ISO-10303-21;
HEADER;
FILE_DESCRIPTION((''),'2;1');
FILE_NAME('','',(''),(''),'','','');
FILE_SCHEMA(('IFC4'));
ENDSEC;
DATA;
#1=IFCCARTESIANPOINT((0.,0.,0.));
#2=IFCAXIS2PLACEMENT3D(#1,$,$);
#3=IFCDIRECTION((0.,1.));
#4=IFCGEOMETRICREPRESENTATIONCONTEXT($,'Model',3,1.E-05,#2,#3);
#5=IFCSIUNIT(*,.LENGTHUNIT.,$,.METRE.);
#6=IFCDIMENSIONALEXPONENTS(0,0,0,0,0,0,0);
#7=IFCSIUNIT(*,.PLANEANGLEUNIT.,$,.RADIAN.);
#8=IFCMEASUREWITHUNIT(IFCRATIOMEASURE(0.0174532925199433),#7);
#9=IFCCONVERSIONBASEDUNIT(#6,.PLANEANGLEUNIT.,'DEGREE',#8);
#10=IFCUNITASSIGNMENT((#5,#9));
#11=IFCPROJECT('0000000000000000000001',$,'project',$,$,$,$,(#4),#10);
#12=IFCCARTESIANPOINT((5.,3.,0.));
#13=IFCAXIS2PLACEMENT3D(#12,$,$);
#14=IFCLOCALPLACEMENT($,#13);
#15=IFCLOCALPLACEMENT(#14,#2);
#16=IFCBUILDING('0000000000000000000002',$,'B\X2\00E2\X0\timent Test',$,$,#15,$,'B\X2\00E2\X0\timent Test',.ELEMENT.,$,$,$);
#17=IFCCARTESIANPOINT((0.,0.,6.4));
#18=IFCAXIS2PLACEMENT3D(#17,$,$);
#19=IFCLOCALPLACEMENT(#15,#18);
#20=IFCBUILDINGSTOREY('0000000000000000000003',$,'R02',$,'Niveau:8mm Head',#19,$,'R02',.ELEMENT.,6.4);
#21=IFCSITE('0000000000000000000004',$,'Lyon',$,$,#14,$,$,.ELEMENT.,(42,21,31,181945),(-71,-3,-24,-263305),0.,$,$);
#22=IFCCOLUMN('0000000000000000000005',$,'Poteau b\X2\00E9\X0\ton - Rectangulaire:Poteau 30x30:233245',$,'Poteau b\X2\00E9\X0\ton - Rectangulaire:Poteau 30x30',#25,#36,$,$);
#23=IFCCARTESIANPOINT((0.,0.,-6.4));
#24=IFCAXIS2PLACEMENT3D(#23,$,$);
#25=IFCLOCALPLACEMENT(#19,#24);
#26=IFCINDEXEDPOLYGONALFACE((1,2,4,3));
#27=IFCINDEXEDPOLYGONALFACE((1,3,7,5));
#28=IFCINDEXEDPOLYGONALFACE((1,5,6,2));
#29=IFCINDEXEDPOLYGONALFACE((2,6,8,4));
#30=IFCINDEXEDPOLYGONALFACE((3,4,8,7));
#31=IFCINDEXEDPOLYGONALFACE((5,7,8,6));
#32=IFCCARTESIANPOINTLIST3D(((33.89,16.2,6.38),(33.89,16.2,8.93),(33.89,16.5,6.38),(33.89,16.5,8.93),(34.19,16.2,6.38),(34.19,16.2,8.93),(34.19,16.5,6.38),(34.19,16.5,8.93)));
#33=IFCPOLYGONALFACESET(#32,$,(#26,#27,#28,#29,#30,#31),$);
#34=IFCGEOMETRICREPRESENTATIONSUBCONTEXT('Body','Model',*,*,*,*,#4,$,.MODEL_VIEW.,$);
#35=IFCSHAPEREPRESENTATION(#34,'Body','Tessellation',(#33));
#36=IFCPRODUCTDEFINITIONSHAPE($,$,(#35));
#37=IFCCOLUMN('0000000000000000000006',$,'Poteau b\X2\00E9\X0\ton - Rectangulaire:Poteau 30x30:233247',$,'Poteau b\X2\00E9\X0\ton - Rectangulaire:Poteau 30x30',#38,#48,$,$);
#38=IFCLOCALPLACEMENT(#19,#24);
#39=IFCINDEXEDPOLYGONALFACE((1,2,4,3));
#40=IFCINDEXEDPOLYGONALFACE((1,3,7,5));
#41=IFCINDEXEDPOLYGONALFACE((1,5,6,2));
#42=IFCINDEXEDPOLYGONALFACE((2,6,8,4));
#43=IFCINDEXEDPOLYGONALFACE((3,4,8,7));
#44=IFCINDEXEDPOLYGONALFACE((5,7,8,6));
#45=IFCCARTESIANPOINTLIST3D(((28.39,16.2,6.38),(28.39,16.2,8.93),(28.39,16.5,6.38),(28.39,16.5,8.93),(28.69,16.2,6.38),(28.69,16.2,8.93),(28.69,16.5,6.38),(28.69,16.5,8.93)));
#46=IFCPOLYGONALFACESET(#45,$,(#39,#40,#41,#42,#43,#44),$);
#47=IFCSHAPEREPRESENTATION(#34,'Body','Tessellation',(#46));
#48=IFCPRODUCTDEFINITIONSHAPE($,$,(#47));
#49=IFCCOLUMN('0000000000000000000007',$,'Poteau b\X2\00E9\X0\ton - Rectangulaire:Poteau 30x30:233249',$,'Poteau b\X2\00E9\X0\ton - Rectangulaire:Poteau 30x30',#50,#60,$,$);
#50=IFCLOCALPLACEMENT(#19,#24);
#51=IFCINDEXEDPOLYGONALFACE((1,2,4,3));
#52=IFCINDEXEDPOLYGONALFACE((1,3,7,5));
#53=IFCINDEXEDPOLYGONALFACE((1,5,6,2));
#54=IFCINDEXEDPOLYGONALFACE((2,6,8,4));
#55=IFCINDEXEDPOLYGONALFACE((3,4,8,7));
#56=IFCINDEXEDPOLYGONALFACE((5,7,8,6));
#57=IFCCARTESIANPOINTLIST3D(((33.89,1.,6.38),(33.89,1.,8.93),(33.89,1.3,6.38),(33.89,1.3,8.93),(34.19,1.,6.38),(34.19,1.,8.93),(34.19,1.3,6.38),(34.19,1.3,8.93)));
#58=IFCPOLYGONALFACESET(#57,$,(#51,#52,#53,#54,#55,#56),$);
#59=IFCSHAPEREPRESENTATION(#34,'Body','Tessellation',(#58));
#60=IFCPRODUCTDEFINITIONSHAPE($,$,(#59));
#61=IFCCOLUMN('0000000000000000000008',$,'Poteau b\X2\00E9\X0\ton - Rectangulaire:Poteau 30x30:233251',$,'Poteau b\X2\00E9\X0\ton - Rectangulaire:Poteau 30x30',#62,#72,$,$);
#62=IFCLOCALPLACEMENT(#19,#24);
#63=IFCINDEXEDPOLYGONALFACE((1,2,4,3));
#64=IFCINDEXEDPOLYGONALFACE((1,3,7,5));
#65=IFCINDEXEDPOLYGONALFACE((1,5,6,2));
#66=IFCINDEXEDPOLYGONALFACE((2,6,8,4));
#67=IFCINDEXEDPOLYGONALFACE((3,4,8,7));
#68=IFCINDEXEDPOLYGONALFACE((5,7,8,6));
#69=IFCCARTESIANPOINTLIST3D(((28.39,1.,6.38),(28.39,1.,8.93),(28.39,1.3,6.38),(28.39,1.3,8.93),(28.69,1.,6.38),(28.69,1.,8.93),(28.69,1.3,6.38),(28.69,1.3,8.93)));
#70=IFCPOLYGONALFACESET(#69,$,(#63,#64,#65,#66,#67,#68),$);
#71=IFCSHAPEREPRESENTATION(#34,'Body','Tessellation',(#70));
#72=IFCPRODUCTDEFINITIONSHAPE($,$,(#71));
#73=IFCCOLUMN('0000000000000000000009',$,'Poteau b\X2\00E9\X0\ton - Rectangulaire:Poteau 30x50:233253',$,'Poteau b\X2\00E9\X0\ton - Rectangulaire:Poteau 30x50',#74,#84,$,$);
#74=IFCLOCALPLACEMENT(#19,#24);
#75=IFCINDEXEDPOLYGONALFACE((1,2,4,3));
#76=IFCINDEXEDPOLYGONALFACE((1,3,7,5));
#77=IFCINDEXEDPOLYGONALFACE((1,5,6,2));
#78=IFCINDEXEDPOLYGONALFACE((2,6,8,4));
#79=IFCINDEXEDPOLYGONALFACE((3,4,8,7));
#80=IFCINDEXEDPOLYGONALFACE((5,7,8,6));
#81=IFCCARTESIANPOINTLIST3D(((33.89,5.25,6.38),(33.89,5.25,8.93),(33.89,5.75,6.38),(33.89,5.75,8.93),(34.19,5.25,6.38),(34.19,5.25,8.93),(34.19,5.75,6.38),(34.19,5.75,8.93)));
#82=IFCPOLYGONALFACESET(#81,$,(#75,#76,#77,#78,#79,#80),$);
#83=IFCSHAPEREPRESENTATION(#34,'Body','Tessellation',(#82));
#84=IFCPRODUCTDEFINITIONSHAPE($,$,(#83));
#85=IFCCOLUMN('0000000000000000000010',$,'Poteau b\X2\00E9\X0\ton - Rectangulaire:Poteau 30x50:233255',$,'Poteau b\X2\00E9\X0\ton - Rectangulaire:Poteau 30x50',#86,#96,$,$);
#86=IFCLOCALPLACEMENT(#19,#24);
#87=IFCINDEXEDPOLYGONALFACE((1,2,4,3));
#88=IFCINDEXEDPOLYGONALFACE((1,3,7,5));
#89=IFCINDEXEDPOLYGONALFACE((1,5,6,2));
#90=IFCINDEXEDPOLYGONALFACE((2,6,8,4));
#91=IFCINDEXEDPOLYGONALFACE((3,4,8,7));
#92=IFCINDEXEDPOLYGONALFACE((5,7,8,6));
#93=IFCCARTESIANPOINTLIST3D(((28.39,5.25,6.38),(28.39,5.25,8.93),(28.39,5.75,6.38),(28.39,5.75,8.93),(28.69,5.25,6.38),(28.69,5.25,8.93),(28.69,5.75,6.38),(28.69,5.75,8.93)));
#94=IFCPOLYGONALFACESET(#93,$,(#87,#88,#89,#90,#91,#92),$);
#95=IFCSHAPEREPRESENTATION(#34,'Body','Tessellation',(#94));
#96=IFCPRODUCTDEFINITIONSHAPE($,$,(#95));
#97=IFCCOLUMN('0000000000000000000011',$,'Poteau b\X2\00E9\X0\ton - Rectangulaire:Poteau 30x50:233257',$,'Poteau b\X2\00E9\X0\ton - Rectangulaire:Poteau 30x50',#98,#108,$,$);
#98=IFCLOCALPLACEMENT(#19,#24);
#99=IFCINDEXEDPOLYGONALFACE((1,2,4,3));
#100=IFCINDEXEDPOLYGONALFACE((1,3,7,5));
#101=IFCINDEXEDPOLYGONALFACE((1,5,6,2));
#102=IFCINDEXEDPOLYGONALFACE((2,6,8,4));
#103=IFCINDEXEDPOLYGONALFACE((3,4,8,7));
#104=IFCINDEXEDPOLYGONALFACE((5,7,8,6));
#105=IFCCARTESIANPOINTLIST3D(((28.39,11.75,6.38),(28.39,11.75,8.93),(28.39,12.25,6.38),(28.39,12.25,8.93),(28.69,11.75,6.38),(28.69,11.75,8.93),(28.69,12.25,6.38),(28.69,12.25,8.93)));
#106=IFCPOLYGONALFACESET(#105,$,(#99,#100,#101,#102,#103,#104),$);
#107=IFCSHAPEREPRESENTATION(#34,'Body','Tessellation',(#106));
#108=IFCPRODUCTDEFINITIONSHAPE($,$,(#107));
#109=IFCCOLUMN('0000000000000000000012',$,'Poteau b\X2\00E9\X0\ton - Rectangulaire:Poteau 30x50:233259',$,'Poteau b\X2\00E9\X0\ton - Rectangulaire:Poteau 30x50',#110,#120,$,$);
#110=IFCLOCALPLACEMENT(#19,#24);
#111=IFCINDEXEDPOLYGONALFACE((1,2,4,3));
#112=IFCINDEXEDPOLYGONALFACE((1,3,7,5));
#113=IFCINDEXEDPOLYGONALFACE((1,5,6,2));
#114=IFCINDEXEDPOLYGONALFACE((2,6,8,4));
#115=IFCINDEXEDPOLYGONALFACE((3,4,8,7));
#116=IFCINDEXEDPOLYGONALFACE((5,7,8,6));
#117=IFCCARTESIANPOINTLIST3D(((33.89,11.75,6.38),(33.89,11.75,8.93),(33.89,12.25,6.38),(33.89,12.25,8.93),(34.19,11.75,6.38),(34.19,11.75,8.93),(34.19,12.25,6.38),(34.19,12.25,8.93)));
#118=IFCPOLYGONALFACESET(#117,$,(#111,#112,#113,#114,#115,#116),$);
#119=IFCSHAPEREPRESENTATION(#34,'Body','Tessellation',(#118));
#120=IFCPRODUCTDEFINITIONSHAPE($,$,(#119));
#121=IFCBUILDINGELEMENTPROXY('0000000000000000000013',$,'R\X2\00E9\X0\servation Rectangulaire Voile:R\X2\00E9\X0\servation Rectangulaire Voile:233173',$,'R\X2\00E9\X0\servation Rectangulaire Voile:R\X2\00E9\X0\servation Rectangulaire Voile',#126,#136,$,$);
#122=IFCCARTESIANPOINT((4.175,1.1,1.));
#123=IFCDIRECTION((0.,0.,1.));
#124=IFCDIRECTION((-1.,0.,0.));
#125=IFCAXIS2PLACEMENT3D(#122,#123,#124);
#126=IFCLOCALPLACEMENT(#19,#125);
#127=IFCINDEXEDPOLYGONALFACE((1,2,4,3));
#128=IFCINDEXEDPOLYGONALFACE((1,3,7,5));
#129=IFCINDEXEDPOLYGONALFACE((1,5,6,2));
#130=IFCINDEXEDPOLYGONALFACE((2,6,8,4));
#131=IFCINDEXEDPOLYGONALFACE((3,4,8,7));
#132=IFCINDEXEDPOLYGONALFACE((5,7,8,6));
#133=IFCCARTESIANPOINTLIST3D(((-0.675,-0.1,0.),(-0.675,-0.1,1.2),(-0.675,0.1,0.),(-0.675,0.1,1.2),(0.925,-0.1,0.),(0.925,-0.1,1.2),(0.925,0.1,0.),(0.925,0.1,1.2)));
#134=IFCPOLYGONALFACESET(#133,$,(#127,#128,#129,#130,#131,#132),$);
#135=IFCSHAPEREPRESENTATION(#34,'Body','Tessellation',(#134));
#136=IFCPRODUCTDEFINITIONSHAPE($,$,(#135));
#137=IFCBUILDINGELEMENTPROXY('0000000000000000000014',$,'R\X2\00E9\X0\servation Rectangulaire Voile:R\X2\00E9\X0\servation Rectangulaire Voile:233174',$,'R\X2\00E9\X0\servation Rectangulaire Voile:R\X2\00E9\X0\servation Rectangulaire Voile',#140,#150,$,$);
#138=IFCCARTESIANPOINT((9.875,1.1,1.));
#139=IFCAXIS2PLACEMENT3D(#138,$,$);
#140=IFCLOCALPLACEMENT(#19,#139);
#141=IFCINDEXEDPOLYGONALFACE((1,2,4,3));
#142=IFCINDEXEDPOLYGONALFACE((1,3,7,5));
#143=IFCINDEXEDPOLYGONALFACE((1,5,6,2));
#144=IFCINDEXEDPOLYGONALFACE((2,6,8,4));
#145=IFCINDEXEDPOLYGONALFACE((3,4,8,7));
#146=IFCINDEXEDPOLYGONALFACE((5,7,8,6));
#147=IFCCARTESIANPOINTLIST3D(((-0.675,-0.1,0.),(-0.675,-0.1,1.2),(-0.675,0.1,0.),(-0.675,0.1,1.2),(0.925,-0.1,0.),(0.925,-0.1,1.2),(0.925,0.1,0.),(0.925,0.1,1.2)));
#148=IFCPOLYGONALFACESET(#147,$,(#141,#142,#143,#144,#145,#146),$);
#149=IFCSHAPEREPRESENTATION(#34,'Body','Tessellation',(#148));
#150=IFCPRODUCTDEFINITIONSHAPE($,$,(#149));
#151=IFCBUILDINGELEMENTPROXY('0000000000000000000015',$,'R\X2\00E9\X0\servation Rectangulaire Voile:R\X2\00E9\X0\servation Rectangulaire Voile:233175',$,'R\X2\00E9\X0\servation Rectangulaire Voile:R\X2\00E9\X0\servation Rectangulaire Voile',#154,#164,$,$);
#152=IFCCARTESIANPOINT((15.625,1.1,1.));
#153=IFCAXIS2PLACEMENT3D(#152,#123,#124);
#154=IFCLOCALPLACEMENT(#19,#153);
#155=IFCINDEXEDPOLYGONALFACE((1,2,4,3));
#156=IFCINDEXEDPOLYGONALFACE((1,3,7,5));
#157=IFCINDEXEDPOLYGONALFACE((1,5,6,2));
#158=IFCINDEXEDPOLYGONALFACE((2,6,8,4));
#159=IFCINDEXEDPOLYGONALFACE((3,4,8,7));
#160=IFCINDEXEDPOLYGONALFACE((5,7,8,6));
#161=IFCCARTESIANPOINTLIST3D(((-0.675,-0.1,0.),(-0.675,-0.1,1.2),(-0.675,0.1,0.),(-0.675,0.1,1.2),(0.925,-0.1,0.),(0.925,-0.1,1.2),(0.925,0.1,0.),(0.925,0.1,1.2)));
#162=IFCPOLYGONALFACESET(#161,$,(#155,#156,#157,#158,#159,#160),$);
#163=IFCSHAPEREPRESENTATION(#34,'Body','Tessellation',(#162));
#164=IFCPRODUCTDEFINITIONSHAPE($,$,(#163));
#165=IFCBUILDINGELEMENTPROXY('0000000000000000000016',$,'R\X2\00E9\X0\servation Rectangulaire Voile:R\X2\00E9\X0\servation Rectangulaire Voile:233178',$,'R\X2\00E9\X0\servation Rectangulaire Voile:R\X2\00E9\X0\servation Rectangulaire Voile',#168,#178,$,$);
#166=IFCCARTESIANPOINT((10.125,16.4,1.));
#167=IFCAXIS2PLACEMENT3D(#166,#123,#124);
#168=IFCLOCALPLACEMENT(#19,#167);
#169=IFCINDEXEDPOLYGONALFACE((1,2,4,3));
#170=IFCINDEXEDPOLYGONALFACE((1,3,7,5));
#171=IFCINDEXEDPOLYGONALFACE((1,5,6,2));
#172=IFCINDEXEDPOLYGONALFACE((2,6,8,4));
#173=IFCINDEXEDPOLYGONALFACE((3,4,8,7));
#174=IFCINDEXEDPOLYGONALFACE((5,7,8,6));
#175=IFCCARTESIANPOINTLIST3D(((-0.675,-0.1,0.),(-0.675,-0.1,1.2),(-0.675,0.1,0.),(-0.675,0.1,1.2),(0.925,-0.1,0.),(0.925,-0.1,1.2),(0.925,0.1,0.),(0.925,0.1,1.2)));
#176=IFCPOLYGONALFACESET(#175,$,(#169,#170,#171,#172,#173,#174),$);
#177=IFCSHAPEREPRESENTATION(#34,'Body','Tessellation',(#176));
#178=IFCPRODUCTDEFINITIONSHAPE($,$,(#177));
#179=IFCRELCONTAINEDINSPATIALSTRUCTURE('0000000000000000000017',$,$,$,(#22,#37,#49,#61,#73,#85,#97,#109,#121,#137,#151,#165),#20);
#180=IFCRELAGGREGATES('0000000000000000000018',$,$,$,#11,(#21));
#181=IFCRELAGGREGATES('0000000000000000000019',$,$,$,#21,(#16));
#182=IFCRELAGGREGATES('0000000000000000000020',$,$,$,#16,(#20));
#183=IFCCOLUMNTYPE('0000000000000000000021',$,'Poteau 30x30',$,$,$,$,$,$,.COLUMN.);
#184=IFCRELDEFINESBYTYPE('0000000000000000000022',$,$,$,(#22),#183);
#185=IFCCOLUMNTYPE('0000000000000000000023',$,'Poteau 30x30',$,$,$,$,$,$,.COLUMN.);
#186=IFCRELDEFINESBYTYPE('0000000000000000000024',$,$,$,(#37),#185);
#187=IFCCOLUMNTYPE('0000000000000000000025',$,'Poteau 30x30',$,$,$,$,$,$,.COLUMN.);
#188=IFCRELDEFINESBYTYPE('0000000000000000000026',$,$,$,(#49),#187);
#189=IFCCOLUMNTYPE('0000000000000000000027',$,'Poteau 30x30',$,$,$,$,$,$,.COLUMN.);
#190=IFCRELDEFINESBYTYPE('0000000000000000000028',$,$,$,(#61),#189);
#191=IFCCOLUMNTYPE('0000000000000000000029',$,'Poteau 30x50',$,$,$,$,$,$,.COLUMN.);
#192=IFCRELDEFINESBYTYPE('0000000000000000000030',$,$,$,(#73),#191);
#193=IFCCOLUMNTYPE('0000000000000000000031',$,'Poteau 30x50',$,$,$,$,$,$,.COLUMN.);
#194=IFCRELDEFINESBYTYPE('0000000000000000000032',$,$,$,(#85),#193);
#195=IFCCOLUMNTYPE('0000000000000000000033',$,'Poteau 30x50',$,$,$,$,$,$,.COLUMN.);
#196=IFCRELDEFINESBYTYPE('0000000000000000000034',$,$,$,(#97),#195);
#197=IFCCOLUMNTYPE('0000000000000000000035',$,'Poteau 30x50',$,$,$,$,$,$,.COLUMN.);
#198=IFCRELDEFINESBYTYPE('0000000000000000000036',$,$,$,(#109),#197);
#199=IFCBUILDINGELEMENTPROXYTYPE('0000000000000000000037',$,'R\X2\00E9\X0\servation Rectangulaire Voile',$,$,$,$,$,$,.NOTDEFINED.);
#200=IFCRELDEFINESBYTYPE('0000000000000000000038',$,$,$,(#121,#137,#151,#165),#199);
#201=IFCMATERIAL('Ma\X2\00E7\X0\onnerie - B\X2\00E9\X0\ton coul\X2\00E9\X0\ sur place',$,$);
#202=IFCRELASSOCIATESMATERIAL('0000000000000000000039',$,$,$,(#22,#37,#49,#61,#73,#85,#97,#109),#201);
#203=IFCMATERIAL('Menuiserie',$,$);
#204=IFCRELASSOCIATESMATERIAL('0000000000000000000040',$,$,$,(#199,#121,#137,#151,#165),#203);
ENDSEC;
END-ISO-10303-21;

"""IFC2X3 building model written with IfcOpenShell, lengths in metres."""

from ifc_helpers import new_model, entity, si_unit, converted_unit, direction, frame, frame_2d, origin, origin_2d_with_axis, place, context, subcontext, project, spatial, rectangle, extrude, source, transform, mapped, material, type_object, type_shapes, element, save


model = new_model("IFC2X3")

# Units and contexts
model_context = context("Model", 3, precision=1e-05, world=origin(), true_north=direction((0.0, 1.0)))
body_context = subcontext(model_context, "Body", "Model", "MODEL_VIEW")
ifc_project = project(units=[si_unit("LENGTHUNIT", "METRE"), converted_unit("PLANEANGLEUNIT", "DEGREE", entity("IfcRatioMeasure", 0.0174532925199433), si_unit("PLANEANGLEUNIT", "RADIAN"), dimensions=[0, 0, 0, 0, 0, 0, 0])], contexts=[model_context])

# Site, building, storey
site_placement = place(None, frame((5.0, 3.0, 0.0)))
site = spatial("IfcSite", under=ifc_project, at=site_placement, Name="Lyon", CompositionType="ELEMENT", RefLatitude=(42, 21, 31, 181945), RefLongitude=(-71, -3, -24, -263305), RefElevation=0.0)
building_placement = place(site_placement, origin())
building = spatial("IfcBuilding", under=site, at=building_placement, Name="Bâtiment Test", LongName="Bâtiment Test", CompositionType="ELEMENT")
storey_placement = place(building_placement, frame((0.0, 0.0, 6.4)))
storey = spatial("IfcBuildingStorey", under=building, at=storey_placement, Name="R02", ObjectType="Niveau:8mm Head", LongName="R02", CompositionType="ELEMENT", Elevation=6.4)

# Columns
ifc_material_1 = material(Name="Maçonnerie - Béton coulé sur place")
column_type_1 = type_object("IfcColumnType", Name="Poteau 30x30", PredefinedType="COLUMN")
shared_shape_1 = source(origin(), body_context, "Body", "SweptSolid", [
    extrude(rectangle(XDim=0.3, YDim=0.3, at=origin_2d_with_axis()), frame((34.04, 16.35, 6.38), z_axis=(0.0, 0.0, 1.0), x_axis=(0.0, -1.0, 0.0)), (0.0, 0.0, 1.0), 2.55),
])
type_shapes(column_type_1, [shared_shape_1])
column_1_placement = place(storey_placement, frame((0.0, 0.0, -6.4)))
element("IfcColumn", 1, at=column_1_placement, inside=storey, type_object=column_type_1, material=ifc_material_1, Name="Poteau béton - Rectangulaire:Poteau 30x30:233245", ObjectType="Poteau béton - Rectangulaire:Poteau 30x30", context=body_context, shape_type="MappedRepresentation", body=[
    mapped(shared_shape_1, transform((0.0, 0.0, 0.0), scale=1.0)),
])
column_type_2 = type_object("IfcColumnType", Name="Poteau 30x30", PredefinedType="COLUMN")
shared_shape_2 = source(origin(), body_context, "Body", "SweptSolid", [
    extrude(rectangle(XDim=0.3, YDim=0.3, at=origin_2d_with_axis()), frame((28.54, 16.35, 6.38), z_axis=(0.0, 0.0, 1.0), x_axis=(0.0, -1.0, 0.0)), (0.0, 0.0, 1.0), 2.55),
])
type_shapes(column_type_2, [shared_shape_2])
column_2_placement = place(storey_placement, frame((0.0, 0.0, -6.4)))
element("IfcColumn", 2, at=column_2_placement, inside=storey, type_object=column_type_2, material=ifc_material_1, Name="Poteau béton - Rectangulaire:Poteau 30x30:233247", ObjectType="Poteau béton - Rectangulaire:Poteau 30x30", context=body_context, shape_type="MappedRepresentation", body=[
    mapped(shared_shape_2, transform((0.0, 0.0, 0.0), scale=1.0)),
])
column_type_3 = type_object("IfcColumnType", Name="Poteau 30x30", PredefinedType="COLUMN")
shared_shape_3 = source(origin(), body_context, "Body", "SweptSolid", [
    extrude(rectangle(XDim=0.3, YDim=0.3, at=frame_2d((0.0, 0.0), x_axis=(1.0, 0.0))), frame((34.04, 1.15, 6.38), z_axis=(0.0, 0.0, 1.0), x_axis=(0.0, -1.0, 0.0)), (0.0, 0.0, 1.0), 2.55),
])
type_shapes(column_type_3, [shared_shape_3])
column_3_placement = place(storey_placement, frame((0.0, 0.0, -6.4)))
element("IfcColumn", 3, at=column_3_placement, inside=storey, type_object=column_type_3, material=ifc_material_1, Name="Poteau béton - Rectangulaire:Poteau 30x30:233249", ObjectType="Poteau béton - Rectangulaire:Poteau 30x30", context=body_context, shape_type="MappedRepresentation", body=[
    mapped(shared_shape_3, transform((0.0, 0.0, 0.0), scale=1.0)),
])
column_type_4 = type_object("IfcColumnType", Name="Poteau 30x30", PredefinedType="COLUMN")
shared_shape_4 = source(origin(), body_context, "Body", "SweptSolid", [
    extrude(rectangle(XDim=0.3, YDim=0.3, at=frame_2d((0.0, 0.0), x_axis=(1.0, 0.0))), frame((28.54, 1.15, 6.38), z_axis=(0.0, 0.0, 1.0), x_axis=(0.0, -1.0, 0.0)), (0.0, 0.0, 1.0), 2.55),
])
type_shapes(column_type_4, [shared_shape_4])
column_4_placement = place(storey_placement, frame((0.0, 0.0, -6.4)))
element("IfcColumn", 4, at=column_4_placement, inside=storey, type_object=column_type_4, material=ifc_material_1, Name="Poteau béton - Rectangulaire:Poteau 30x30:233251", ObjectType="Poteau béton - Rectangulaire:Poteau 30x30", context=body_context, shape_type="MappedRepresentation", body=[
    mapped(shared_shape_4, transform((0.0, 0.0, 0.0), scale=1.0)),
])
column_type_5 = type_object("IfcColumnType", Name="Poteau 30x50", PredefinedType="COLUMN")
shared_shape_5 = source(origin(), body_context, "Body", "SweptSolid", [
    extrude(rectangle(XDim=0.5, YDim=0.3, at=origin_2d_with_axis()), frame((34.04, 5.5, 6.38), z_axis=(0.0, 0.0, 1.0), x_axis=(0.0, -1.0, 0.0)), (0.0, 0.0, 1.0), 2.55),
])
type_shapes(column_type_5, [shared_shape_5])
column_5_placement = place(storey_placement, frame((0.0, 0.0, -6.4)))
element("IfcColumn", 5, at=column_5_placement, inside=storey, type_object=column_type_5, material=ifc_material_1, Name="Poteau béton - Rectangulaire:Poteau 30x50:233253", ObjectType="Poteau béton - Rectangulaire:Poteau 30x50", context=body_context, shape_type="MappedRepresentation", body=[
    mapped(shared_shape_5, transform((0.0, 0.0, 0.0), scale=1.0)),
])
column_type_6 = type_object("IfcColumnType", Name="Poteau 30x50", PredefinedType="COLUMN")
shared_shape_6 = source(origin(), body_context, "Body", "SweptSolid", [
    extrude(rectangle(XDim=0.5, YDim=0.3, at=origin_2d_with_axis()), frame((28.54, 5.5, 6.38), z_axis=(0.0, 0.0, 1.0), x_axis=(0.0, -1.0, 0.0)), (0.0, 0.0, 1.0), 2.55),
])
type_shapes(column_type_6, [shared_shape_6])
column_6_placement = place(storey_placement, frame((0.0, 0.0, -6.4)))
element("IfcColumn", 6, at=column_6_placement, inside=storey, type_object=column_type_6, material=ifc_material_1, Name="Poteau béton - Rectangulaire:Poteau 30x50:233255", ObjectType="Poteau béton - Rectangulaire:Poteau 30x50", context=body_context, shape_type="MappedRepresentation", body=[
    mapped(shared_shape_6, transform((0.0, 0.0, 0.0), scale=1.0)),
])
column_type_7 = type_object("IfcColumnType", Name="Poteau 30x50", PredefinedType="COLUMN")
shared_shape_7 = source(origin(), body_context, "Body", "SweptSolid", [
    extrude(rectangle(XDim=0.5, YDim=0.3, at=origin_2d_with_axis()), frame((28.54, 12.0, 6.38), z_axis=(0.0, 0.0, 1.0), x_axis=(0.0, -1.0, 0.0)), (0.0, 0.0, 1.0), 2.55),
])
type_shapes(column_type_7, [shared_shape_7])
column_7_placement = place(storey_placement, frame((0.0, 0.0, -6.4)))
element("IfcColumn", 7, at=column_7_placement, inside=storey, type_object=column_type_7, material=ifc_material_1, Name="Poteau béton - Rectangulaire:Poteau 30x50:233257", ObjectType="Poteau béton - Rectangulaire:Poteau 30x50", context=body_context, shape_type="MappedRepresentation", body=[
    mapped(shared_shape_7, transform((0.0, 0.0, 0.0), scale=1.0)),
])
column_type_8 = type_object("IfcColumnType", Name="Poteau 30x50", PredefinedType="COLUMN")
shared_shape_8 = source(origin(), body_context, "Body", "SweptSolid", [
    extrude(rectangle(XDim=0.5, YDim=0.3, at=origin_2d_with_axis()), frame((34.04, 12.0, 6.38), z_axis=(0.0, 0.0, 1.0), x_axis=(0.0, -1.0, 0.0)), (0.0, 0.0, 1.0), 2.55),
])
type_shapes(column_type_8, [shared_shape_8])
column_8_placement = place(storey_placement, frame((0.0, 0.0, -6.4)))
element("IfcColumn", 8, at=column_8_placement, inside=storey, type_object=column_type_8, material=ifc_material_1, Name="Poteau béton - Rectangulaire:Poteau 30x50:233259", ObjectType="Poteau béton - Rectangulaire:Poteau 30x50", context=body_context, shape_type="MappedRepresentation", body=[
    mapped(shared_shape_8, transform((0.0, 0.0, 0.0), scale=1.0)),
])

# Building element proxies
ifc_material_2 = material(Name="Menuiserie")
building_element_proxy_type_1 = type_object("IfcBuildingElementProxyType", Name="Réservation Rectangulaire Voile", PredefinedType="NOTDEFINED", material=ifc_material_2)
shared_shape_9 = source(origin(), body_context, "Body", "SweptSolid", [
    extrude(rectangle(XDim=0.2, YDim=1.6, at=origin_2d_with_axis()), frame((0.125, 0.0, 0.0), z_axis=(0.0, 0.0, 1.0), x_axis=(0.0, 1.0, 0.0)), (0.0, 0.0, 1.0), 1.2),
])
type_shapes(building_element_proxy_type_1, [shared_shape_9])
proxy_1_placement = place(storey_placement, frame((4.175, 1.1, 1.0), z_axis=(0.0, 0.0, 1.0), x_axis=(-1.0, 0.0, 0.0)))
element("IfcBuildingElementProxy", 9, at=proxy_1_placement, inside=storey, type_object=building_element_proxy_type_1, material=ifc_material_2, Name="Réservation Rectangulaire Voile:Réservation Rectangulaire Voile:233173", ObjectType="Réservation Rectangulaire Voile:Réservation Rectangulaire Voile", context=body_context, shape_type="MappedRepresentation", body=[
    mapped(shared_shape_9, transform((0.0, 0.0, 0.0), scale=1.0)),
])
proxy_2_placement = place(storey_placement, frame((9.875, 1.1, 1.0)))
element("IfcBuildingElementProxy", 10, at=proxy_2_placement, inside=storey, type_object=building_element_proxy_type_1, material=ifc_material_2, Name="Réservation Rectangulaire Voile:Réservation Rectangulaire Voile:233174", ObjectType="Réservation Rectangulaire Voile:Réservation Rectangulaire Voile", context=body_context, shape_type="MappedRepresentation", body=[
    mapped(shared_shape_9, transform((0.0, 0.0, 0.0), scale=1.0)),
])
for number, where, z_axis, x_axis, name in (
    (11, (15.625, 1.1, 1.0), (0.0, 0.0, 1.0), (-1.0, 0.0, 0.0), "Réservation Rectangulaire Voile:Réservation Rectangulaire Voile:233175"),
    (12, (10.125, 16.4, 1.0), (0.0, 0.0, 1.0), (-1.0, 0.0, 0.0), "Réservation Rectangulaire Voile:Réservation Rectangulaire Voile:233178"),
):
    element("IfcBuildingElementProxy", number, at=place(storey_placement, frame(where, z_axis=z_axis, x_axis=x_axis)), inside=storey, type_object=building_element_proxy_type_1, material=ifc_material_2, Name=name, ObjectType="Réservation Rectangulaire Voile:Réservation Rectangulaire Voile", context=body_context, shape_type="MappedRepresentation", body=[
        mapped(shared_shape_9, transform((0.0, 0.0, 0.0), scale=1.0)),
    ])

save(model, "model.ifc")
